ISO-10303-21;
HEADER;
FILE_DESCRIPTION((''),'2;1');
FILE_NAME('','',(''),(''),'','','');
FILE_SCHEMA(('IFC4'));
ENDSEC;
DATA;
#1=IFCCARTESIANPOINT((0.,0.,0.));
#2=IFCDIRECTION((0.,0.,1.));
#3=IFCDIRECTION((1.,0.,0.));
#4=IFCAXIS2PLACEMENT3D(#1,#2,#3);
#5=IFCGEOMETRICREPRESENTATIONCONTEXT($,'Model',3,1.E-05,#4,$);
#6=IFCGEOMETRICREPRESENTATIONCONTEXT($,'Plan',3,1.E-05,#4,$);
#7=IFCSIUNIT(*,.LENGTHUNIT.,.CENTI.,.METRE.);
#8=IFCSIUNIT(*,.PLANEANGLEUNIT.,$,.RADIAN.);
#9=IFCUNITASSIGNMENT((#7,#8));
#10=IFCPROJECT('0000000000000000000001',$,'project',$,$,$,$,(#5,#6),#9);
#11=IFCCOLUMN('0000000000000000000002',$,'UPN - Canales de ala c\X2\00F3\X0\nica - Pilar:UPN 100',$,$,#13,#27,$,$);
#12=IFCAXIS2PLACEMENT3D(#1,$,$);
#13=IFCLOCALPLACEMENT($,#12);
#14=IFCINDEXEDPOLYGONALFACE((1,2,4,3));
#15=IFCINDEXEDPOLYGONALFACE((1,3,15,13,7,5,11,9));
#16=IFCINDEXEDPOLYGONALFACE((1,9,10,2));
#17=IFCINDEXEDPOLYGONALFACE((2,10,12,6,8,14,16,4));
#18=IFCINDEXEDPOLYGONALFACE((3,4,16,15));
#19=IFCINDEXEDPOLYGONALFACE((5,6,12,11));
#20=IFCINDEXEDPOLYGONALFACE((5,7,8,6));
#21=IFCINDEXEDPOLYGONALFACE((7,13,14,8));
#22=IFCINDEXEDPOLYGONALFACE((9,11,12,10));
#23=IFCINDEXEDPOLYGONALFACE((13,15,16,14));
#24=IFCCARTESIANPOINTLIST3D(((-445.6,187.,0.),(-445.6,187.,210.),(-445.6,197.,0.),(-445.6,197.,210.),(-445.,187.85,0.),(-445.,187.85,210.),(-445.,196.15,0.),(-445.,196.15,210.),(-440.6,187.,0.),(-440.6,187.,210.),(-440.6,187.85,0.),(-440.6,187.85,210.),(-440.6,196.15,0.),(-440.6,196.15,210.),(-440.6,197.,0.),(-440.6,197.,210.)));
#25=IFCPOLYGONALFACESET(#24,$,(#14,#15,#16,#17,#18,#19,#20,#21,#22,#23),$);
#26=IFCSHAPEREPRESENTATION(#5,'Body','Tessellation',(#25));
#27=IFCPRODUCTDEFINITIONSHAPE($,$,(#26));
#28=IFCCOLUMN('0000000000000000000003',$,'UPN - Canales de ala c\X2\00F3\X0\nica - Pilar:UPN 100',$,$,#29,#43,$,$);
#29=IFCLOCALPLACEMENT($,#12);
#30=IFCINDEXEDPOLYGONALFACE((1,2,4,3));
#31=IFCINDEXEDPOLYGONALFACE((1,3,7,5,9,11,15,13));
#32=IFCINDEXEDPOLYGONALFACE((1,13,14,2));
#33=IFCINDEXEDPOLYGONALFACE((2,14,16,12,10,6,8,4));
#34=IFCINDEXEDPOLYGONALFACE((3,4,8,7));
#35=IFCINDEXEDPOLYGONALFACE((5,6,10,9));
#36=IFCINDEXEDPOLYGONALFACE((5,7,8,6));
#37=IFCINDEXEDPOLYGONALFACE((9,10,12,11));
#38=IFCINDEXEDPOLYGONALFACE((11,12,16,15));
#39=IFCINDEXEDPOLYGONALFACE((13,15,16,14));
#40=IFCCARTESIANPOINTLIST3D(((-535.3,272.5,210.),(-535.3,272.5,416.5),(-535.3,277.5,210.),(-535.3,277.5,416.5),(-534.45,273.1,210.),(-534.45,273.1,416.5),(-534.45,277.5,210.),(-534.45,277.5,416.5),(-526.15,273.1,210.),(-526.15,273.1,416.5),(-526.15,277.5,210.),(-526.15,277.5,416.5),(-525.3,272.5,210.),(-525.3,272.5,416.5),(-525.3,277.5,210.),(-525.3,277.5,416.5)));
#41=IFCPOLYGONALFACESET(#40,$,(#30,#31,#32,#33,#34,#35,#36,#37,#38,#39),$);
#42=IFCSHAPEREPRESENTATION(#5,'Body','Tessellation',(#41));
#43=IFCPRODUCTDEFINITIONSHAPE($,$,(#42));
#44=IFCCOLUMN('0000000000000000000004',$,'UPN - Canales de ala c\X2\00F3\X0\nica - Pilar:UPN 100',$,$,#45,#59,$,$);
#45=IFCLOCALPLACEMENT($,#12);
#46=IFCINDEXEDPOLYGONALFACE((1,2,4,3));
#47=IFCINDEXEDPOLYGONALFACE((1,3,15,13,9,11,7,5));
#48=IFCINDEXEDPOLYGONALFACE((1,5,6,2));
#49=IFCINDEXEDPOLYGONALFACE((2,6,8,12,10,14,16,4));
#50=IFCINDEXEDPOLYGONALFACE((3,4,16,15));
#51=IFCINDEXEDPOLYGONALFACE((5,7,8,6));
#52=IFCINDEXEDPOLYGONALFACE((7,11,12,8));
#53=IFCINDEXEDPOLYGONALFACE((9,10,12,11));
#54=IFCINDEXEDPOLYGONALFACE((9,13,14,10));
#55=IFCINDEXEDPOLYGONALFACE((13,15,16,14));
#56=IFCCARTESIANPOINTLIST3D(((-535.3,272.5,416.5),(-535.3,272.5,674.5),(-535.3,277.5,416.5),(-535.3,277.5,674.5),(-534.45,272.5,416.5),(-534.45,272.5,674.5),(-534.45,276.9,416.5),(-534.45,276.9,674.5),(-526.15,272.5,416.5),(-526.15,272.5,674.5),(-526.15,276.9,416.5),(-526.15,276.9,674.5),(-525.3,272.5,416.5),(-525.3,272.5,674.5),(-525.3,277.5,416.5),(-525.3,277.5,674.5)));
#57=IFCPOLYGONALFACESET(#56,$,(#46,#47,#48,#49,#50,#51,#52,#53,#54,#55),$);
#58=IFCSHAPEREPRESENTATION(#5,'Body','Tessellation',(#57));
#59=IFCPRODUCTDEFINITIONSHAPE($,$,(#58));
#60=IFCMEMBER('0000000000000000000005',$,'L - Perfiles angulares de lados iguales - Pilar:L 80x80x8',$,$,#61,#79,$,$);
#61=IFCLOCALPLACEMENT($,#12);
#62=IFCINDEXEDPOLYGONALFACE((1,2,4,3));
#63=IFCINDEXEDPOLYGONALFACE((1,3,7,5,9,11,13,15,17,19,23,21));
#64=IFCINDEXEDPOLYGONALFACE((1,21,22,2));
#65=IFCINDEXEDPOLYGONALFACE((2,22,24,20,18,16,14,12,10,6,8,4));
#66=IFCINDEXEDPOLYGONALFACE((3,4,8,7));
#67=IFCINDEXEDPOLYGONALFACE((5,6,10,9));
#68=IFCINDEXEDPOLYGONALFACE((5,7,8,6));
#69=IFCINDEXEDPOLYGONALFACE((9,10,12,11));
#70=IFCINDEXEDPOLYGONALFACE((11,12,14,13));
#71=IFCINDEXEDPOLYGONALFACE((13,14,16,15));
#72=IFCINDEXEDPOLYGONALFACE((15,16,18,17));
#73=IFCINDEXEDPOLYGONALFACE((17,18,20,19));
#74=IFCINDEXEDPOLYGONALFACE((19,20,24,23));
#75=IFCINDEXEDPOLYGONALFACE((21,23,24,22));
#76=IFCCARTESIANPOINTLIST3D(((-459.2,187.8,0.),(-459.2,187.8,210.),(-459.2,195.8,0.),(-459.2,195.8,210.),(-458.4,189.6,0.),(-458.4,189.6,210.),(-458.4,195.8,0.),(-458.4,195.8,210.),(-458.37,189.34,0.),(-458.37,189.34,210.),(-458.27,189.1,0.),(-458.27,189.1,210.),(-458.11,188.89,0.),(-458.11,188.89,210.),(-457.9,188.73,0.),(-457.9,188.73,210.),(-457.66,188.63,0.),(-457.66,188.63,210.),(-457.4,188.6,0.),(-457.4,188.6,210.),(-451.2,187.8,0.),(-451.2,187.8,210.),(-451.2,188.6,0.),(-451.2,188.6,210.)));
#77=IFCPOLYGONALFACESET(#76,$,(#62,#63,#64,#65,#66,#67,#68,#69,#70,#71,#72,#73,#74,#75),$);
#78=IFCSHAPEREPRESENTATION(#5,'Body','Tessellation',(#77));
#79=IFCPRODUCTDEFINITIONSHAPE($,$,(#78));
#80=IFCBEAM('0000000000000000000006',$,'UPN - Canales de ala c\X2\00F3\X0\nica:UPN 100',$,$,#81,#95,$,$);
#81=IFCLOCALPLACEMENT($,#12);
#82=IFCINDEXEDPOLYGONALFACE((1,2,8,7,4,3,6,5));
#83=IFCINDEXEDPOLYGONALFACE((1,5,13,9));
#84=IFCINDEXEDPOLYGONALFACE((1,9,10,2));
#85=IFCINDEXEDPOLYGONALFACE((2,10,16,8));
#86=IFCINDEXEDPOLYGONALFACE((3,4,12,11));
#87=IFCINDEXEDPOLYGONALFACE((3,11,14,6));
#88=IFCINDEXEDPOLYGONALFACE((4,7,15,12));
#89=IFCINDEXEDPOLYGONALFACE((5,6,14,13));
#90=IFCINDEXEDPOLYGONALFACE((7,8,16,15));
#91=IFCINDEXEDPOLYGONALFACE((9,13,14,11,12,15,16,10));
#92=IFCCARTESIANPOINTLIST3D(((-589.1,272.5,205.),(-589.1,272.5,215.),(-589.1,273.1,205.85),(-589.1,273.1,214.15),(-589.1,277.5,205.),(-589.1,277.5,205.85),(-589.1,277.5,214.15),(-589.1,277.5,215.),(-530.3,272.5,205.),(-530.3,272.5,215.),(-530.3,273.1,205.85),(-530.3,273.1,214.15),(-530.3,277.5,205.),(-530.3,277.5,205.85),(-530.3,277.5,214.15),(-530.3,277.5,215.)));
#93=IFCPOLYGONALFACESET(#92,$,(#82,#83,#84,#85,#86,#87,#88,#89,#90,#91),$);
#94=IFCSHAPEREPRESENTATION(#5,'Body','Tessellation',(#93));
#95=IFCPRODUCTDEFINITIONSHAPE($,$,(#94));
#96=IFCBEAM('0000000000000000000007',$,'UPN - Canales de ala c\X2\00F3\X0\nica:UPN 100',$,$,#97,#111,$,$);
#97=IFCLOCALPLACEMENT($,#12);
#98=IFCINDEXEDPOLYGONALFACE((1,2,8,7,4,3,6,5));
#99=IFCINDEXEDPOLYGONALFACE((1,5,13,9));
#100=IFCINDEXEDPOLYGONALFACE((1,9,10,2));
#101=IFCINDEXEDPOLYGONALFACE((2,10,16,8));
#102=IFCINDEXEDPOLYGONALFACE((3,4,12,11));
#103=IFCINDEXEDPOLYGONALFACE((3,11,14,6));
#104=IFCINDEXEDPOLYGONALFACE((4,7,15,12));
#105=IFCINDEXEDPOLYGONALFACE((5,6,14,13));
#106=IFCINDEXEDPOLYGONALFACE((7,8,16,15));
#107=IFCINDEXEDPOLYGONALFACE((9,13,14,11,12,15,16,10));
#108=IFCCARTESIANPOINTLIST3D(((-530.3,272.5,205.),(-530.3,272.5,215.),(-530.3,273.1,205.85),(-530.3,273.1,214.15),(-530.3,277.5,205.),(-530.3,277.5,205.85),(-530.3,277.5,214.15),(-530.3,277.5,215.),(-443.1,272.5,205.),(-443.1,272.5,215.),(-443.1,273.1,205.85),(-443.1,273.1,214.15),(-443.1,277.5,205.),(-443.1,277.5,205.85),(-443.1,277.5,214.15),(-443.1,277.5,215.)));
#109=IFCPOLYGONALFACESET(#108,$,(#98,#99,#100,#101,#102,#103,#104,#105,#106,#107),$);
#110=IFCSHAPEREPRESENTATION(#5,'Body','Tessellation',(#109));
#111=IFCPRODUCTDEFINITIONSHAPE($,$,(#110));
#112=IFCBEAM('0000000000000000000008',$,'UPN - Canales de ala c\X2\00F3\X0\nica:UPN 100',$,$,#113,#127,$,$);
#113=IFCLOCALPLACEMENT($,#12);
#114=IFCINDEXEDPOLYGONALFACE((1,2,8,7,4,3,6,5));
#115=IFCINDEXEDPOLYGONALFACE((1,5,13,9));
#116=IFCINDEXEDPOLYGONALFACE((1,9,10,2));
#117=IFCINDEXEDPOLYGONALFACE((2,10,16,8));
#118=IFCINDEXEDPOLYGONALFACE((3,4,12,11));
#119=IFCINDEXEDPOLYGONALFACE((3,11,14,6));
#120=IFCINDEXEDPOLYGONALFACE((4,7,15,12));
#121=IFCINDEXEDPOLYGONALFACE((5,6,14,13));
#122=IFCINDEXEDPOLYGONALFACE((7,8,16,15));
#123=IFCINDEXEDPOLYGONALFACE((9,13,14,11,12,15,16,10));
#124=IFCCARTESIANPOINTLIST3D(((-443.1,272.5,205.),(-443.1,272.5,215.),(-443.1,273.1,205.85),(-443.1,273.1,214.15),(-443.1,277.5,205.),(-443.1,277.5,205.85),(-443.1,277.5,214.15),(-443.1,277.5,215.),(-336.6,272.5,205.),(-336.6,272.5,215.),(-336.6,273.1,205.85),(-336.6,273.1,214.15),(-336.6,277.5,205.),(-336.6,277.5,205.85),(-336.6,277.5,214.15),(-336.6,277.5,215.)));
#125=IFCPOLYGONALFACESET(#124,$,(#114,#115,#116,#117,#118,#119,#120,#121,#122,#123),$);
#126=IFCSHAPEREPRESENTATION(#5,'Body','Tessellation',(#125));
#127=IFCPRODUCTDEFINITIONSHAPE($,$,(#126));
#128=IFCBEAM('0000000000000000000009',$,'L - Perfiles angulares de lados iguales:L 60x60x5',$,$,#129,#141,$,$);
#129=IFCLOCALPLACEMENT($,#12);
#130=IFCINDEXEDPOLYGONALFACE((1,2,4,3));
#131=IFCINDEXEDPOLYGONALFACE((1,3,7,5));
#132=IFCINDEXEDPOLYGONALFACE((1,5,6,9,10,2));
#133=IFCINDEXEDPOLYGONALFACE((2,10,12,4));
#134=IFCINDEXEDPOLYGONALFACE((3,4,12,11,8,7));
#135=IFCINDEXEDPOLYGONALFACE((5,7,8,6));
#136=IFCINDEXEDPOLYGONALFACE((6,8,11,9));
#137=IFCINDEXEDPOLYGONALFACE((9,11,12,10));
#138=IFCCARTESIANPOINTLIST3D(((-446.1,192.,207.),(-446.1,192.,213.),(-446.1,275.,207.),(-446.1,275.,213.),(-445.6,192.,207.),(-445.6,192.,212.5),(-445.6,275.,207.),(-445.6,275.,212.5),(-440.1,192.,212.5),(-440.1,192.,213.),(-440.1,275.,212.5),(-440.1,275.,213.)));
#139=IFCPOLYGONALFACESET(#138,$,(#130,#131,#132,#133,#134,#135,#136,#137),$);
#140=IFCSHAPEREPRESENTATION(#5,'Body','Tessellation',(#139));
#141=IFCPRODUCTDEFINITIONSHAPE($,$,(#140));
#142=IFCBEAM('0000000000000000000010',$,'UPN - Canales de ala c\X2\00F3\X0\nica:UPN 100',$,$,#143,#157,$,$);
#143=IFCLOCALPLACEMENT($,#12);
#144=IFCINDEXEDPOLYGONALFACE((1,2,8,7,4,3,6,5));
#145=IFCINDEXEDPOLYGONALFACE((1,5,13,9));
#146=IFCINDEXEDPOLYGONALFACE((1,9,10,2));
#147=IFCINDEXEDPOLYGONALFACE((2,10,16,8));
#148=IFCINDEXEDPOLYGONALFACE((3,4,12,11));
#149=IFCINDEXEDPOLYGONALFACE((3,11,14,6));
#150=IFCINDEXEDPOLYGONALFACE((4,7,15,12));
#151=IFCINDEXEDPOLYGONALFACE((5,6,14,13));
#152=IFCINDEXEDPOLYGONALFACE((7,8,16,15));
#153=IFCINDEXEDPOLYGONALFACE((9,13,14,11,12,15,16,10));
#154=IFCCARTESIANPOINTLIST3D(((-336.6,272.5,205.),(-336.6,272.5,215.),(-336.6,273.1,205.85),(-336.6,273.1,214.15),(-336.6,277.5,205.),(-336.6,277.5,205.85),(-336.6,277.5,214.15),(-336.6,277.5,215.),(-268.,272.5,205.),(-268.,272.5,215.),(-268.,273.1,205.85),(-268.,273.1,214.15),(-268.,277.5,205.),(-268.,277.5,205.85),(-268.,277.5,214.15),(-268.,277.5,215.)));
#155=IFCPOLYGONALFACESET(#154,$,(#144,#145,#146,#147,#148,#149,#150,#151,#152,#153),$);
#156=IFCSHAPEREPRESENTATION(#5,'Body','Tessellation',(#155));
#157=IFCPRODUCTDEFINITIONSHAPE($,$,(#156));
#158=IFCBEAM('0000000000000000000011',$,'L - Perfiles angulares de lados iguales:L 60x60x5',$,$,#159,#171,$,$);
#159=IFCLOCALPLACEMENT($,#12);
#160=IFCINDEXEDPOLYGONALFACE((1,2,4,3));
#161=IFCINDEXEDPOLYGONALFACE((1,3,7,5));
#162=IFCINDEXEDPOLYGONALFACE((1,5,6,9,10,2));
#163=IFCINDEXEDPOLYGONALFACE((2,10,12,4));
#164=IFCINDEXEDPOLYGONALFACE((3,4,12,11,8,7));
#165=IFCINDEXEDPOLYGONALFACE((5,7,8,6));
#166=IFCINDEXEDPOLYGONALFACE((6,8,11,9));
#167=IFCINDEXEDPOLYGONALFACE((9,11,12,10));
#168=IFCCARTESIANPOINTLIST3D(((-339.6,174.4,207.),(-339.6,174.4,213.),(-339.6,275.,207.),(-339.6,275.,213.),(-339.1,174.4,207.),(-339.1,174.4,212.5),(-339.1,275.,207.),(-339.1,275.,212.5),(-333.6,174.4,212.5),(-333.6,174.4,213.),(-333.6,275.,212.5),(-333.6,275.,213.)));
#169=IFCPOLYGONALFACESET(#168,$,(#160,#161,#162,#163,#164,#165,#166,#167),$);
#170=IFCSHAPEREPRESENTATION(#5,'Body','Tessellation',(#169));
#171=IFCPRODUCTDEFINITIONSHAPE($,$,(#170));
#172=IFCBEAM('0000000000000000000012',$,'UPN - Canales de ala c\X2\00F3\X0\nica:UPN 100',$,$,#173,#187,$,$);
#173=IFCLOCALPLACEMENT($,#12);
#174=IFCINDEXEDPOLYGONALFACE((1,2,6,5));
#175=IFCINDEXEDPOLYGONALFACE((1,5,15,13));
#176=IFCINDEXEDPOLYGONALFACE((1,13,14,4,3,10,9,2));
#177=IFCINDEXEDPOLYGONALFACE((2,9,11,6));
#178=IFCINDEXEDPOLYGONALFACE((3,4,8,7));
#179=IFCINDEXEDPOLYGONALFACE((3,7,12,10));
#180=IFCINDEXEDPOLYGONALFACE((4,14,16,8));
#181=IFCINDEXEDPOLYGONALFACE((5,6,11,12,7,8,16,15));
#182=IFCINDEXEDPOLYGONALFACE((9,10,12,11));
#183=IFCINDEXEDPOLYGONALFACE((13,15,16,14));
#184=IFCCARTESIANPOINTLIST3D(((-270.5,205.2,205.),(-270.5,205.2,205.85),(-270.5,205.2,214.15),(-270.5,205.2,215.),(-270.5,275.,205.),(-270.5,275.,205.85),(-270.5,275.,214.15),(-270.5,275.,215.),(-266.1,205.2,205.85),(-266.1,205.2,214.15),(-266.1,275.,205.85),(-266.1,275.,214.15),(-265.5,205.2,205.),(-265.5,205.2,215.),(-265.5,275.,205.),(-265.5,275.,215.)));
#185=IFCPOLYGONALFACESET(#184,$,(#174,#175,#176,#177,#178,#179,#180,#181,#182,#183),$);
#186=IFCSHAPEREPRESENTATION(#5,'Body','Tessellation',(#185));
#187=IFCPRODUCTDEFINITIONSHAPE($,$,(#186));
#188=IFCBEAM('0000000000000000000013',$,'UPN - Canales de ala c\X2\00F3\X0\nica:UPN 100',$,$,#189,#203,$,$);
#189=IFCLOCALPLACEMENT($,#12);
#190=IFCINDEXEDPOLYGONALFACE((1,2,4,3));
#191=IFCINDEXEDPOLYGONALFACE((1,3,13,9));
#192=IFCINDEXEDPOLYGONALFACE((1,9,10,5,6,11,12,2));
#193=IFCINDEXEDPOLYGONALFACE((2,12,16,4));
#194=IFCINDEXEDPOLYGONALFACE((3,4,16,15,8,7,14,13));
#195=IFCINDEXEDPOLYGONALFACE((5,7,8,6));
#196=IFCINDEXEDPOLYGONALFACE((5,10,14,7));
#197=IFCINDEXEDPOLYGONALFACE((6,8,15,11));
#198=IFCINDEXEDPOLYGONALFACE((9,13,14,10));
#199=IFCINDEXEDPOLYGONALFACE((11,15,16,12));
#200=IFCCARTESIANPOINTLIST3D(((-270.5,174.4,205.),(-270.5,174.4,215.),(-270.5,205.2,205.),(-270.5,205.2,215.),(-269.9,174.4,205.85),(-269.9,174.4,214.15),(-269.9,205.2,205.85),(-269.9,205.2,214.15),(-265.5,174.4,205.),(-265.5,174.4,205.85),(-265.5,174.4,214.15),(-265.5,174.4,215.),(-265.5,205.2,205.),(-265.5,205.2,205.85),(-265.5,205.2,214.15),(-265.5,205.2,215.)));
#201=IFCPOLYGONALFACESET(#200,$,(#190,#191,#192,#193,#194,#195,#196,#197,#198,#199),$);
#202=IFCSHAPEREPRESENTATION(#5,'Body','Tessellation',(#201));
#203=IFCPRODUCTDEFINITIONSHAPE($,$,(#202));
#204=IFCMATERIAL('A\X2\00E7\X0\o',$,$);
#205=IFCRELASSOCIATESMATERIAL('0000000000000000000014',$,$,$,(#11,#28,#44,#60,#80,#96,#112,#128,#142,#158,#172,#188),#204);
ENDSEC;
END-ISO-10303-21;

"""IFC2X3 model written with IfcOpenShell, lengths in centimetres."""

from ifc_helpers import new_model, si_unit, frame, origin_with_axes, origin_2d_with_axis, place, context, project, polyline, l_section, u_section, outline, extrude, material, element, save


model = new_model("IFC2X3")

# Units and contexts
model_context = context("Model", 3, precision=1e-05, world=origin_with_axes())
plan_context = context("Plan", 3, precision=1e-05, world=origin_with_axes())
ifc_project = project(units=[si_unit("LENGTHUNIT", "METRE", prefix="CENTI"), si_unit("PLANEANGLEUNIT", "RADIAN")], contexts=[model_context, plan_context])

# Columns
ifc_material = material(Name="Aço")
column_1_placement = place(None, frame((-443.1, 192.0, 0.0), z_axis=(0.0, 0.0, 1.0), x_axis=(1.0, 0.0, 0.0)))
element("IfcColumn", 1, at=column_1_placement, material=ifc_material, Name="UPN - Canales de ala cónica - Pilar:UPN 100", context=model_context, shape_type="SweptSolid", body=[
    extrude(u_section(Depth=10.0, FlangeWidth=5.0, WebThickness=0.6, FlangeThickness=0.85, FilletRadius=0.0, EdgeRadius=0.0, FlangeSlope=0.0, CentreOfGravityInX=0.0, at=origin_2d_with_axis()), origin_with_axes(), (0.0, 0.0, 1.0), 210.0),
])
column_2_placement = place(None, frame((-530.3, 275.0, 210.0), z_axis=(0.0, 0.0, 1.0), x_axis=(0.0, 1.0, 0.0)))
element("IfcColumn", 2, at=column_2_placement, material=ifc_material, Name="UPN - Canales de ala cónica - Pilar:UPN 100", context=model_context, shape_type="SweptSolid", body=[
    extrude(u_section(Depth=10.0, FlangeWidth=5.0, WebThickness=0.6, FlangeThickness=0.85, FilletRadius=0.0, EdgeRadius=0.0, FlangeSlope=0.0, CentreOfGravityInX=0.0, at=origin_2d_with_axis()), origin_with_axes(), (0.0, 0.0, 1.0), 206.5),
])
column_3_placement = place(None, frame((-530.3, 275.0, 416.5), z_axis=(0.0, 0.0, 1.0), x_axis=(0.0, -1.0, 0.0)))
element("IfcColumn", 3, at=column_3_placement, material=ifc_material, Name="UPN - Canales de ala cónica - Pilar:UPN 100", context=model_context, shape_type="SweptSolid", body=[
    extrude(u_section(Depth=10.0, FlangeWidth=5.0, WebThickness=0.6, FlangeThickness=0.85, FilletRadius=0.0, EdgeRadius=0.0, FlangeSlope=0.0, CentreOfGravityInX=0.0, at=origin_2d_with_axis()), origin_with_axes(), (0.0, 0.0, 1.0), 258.0),
])

# Member
member_placement = place(None, frame((-455.2, 191.8, 0.0), z_axis=(0.0, 0.0, 1.0), x_axis=(1.0, 0.0, 0.0)))
element("IfcMember", 4, at=member_placement, material=ifc_material, Name="L - Perfiles angulares de lados iguales - Pilar:L 80x80x8", context=model_context, shape_type="SweptSolid", body=[
    extrude(l_section(Depth=8.0, Width=8.0, Thickness=0.8, FilletRadius=1.0, EdgeRadius=0.0, LegSlope=0.0, CentreOfGravityInX=0.0, CentreOfGravityInY=0.0, at=origin_2d_with_axis()), origin_with_axes(), (0.0, 0.0, 1.0), 210.0),
])

# Beams
beam_1_placement = place(None, frame((-530.3, 275.0, 210.0), z_axis=(-1.0, 0.0, 0.0), x_axis=(0.0, 1.0, 0.0)))
element("IfcBeam", 5, at=beam_1_placement, material=ifc_material, Name="UPN - Canales de ala cónica:UPN 100", context=model_context, shape_type="SweptSolid", body=[
    extrude(u_section(Depth=10.0, FlangeWidth=5.0, WebThickness=0.6, FlangeThickness=0.85, FilletRadius=0.0, EdgeRadius=0.0, FlangeSlope=0.0, CentreOfGravityInX=0.0, at=origin_2d_with_axis()), origin_with_axes(), (0.0, 0.0, 1.0), 58.8),
])
beam_2_placement = place(None, frame((-443.1, 275.0, 210.0), z_axis=(-1.0, 0.0, 0.0), x_axis=(0.0, 1.0, 0.0)))
element("IfcBeam", 6, at=beam_2_placement, material=ifc_material, Name="UPN - Canales de ala cónica:UPN 100", context=model_context, shape_type="SweptSolid", body=[
    extrude(u_section(Depth=10.0, FlangeWidth=5.0, WebThickness=0.6, FlangeThickness=0.85, FilletRadius=0.0, EdgeRadius=0.0, FlangeSlope=0.0, CentreOfGravityInX=0.0, at=origin_2d_with_axis()), origin_with_axes(), (0.0, 0.0, 1.0), 87.2),
])
beam_3_placement = place(None, frame((-336.6, 275.0, 210.0), z_axis=(-1.0, 0.0, 0.0), x_axis=(0.0, 1.0, 0.0)))
element("IfcBeam", 7, at=beam_3_placement, material=ifc_material, Name="UPN - Canales de ala cónica:UPN 100", context=model_context, shape_type="SweptSolid", body=[
    extrude(u_section(Depth=10.0, FlangeWidth=5.0, WebThickness=0.6, FlangeThickness=0.85, FilletRadius=0.0, EdgeRadius=0.0, FlangeSlope=0.0, CentreOfGravityInX=0.0, at=origin_2d_with_axis()), origin_with_axes(), (0.0, 0.0, 1.0), 106.5),
])
beam_4_placement = place(None, frame((-443.1, 192.0, 210.0), z_axis=(0.0, 1.0, 0.0), x_axis=(-1.0, 0.0, 0.0)))
element("IfcBeam", 8, at=beam_4_placement, material=ifc_material, Name="L - Perfiles angulares de lados iguales:L 60x60x5", context=model_context, shape_type="SweptSolid", body=[
    extrude(outline(polyline([(3.0, -3.0), (3.0, 3.0), (-3.0, 3.0), (-3.0, 2.5), (2.5, 2.5), (2.5, -3.0), (3.0, -3.0)])), origin_with_axes(), (0.0, 0.0, 1.0), 83.0),
])
beam_5_placement = place(None, frame((-268.0, 275.0, 210.0), z_axis=(-1.0, 0.0, 0.0), x_axis=(0.0, 1.0, 0.0)))
element("IfcBeam", 9, at=beam_5_placement, material=ifc_material, Name="UPN - Canales de ala cónica:UPN 100", context=model_context, shape_type="SweptSolid", body=[
    extrude(u_section(Depth=10.0, FlangeWidth=5.0, WebThickness=0.6, FlangeThickness=0.85, FilletRadius=0.0, EdgeRadius=0.0, FlangeSlope=0.0, CentreOfGravityInX=0.0, at=origin_2d_with_axis()), origin_with_axes(), (0.0, 0.0, 1.0), 68.6),
])
beam_6_placement = place(None, frame((-336.6, 174.4, 210.0), z_axis=(0.0, 1.0, 0.0), x_axis=(-1.0, 0.0, 0.0)))
element("IfcBeam", 10, at=beam_6_placement, material=ifc_material, Name="L - Perfiles angulares de lados iguales:L 60x60x5", context=model_context, shape_type="SweptSolid", body=[
    extrude(outline(polyline([(3.0, -3.0), (3.0, 3.0), (-3.0, 3.0), (-3.0, 2.5), (2.5, 2.5), (2.5, -3.0), (3.0, -3.0)])), origin_with_axes(), (0.0, 0.0, 1.0), 100.6),
])
beam_7_placement = place(None, frame((-268.0, 205.2, 210.0), z_axis=(0.0, 1.0, 0.0), x_axis=(-1.0, 0.0, 0.0)))
element("IfcBeam", 11, at=beam_7_placement, material=ifc_material, Name="UPN - Canales de ala cónica:UPN 100", context=model_context, shape_type="SweptSolid", body=[
    extrude(u_section(Depth=10.0, FlangeWidth=5.0, WebThickness=0.6, FlangeThickness=0.85, FilletRadius=0.0, EdgeRadius=0.0, FlangeSlope=0.0, CentreOfGravityInX=0.0, at=origin_2d_with_axis()), origin_with_axes(), (0.0, 0.0, 1.0), 69.8),
])
beam_8_placement = place(None, frame((-268.0, 174.4, 210.0), z_axis=(0.0, 1.0, 0.0), x_axis=(1.0, 0.0, 0.0)))
element("IfcBeam", 12, at=beam_8_placement, material=ifc_material, Name="UPN - Canales de ala cónica:UPN 100", context=model_context, shape_type="SweptSolid", body=[
    extrude(u_section(Depth=10.0, FlangeWidth=5.0, WebThickness=0.6, FlangeThickness=0.85, FilletRadius=0.0, EdgeRadius=0.0, FlangeSlope=0.0, CentreOfGravityInX=0.0, at=origin_2d_with_axis()), origin_with_axes(), (0.0, 0.0, 1.0), 30.8),
])

save(model, "model.ifc")
